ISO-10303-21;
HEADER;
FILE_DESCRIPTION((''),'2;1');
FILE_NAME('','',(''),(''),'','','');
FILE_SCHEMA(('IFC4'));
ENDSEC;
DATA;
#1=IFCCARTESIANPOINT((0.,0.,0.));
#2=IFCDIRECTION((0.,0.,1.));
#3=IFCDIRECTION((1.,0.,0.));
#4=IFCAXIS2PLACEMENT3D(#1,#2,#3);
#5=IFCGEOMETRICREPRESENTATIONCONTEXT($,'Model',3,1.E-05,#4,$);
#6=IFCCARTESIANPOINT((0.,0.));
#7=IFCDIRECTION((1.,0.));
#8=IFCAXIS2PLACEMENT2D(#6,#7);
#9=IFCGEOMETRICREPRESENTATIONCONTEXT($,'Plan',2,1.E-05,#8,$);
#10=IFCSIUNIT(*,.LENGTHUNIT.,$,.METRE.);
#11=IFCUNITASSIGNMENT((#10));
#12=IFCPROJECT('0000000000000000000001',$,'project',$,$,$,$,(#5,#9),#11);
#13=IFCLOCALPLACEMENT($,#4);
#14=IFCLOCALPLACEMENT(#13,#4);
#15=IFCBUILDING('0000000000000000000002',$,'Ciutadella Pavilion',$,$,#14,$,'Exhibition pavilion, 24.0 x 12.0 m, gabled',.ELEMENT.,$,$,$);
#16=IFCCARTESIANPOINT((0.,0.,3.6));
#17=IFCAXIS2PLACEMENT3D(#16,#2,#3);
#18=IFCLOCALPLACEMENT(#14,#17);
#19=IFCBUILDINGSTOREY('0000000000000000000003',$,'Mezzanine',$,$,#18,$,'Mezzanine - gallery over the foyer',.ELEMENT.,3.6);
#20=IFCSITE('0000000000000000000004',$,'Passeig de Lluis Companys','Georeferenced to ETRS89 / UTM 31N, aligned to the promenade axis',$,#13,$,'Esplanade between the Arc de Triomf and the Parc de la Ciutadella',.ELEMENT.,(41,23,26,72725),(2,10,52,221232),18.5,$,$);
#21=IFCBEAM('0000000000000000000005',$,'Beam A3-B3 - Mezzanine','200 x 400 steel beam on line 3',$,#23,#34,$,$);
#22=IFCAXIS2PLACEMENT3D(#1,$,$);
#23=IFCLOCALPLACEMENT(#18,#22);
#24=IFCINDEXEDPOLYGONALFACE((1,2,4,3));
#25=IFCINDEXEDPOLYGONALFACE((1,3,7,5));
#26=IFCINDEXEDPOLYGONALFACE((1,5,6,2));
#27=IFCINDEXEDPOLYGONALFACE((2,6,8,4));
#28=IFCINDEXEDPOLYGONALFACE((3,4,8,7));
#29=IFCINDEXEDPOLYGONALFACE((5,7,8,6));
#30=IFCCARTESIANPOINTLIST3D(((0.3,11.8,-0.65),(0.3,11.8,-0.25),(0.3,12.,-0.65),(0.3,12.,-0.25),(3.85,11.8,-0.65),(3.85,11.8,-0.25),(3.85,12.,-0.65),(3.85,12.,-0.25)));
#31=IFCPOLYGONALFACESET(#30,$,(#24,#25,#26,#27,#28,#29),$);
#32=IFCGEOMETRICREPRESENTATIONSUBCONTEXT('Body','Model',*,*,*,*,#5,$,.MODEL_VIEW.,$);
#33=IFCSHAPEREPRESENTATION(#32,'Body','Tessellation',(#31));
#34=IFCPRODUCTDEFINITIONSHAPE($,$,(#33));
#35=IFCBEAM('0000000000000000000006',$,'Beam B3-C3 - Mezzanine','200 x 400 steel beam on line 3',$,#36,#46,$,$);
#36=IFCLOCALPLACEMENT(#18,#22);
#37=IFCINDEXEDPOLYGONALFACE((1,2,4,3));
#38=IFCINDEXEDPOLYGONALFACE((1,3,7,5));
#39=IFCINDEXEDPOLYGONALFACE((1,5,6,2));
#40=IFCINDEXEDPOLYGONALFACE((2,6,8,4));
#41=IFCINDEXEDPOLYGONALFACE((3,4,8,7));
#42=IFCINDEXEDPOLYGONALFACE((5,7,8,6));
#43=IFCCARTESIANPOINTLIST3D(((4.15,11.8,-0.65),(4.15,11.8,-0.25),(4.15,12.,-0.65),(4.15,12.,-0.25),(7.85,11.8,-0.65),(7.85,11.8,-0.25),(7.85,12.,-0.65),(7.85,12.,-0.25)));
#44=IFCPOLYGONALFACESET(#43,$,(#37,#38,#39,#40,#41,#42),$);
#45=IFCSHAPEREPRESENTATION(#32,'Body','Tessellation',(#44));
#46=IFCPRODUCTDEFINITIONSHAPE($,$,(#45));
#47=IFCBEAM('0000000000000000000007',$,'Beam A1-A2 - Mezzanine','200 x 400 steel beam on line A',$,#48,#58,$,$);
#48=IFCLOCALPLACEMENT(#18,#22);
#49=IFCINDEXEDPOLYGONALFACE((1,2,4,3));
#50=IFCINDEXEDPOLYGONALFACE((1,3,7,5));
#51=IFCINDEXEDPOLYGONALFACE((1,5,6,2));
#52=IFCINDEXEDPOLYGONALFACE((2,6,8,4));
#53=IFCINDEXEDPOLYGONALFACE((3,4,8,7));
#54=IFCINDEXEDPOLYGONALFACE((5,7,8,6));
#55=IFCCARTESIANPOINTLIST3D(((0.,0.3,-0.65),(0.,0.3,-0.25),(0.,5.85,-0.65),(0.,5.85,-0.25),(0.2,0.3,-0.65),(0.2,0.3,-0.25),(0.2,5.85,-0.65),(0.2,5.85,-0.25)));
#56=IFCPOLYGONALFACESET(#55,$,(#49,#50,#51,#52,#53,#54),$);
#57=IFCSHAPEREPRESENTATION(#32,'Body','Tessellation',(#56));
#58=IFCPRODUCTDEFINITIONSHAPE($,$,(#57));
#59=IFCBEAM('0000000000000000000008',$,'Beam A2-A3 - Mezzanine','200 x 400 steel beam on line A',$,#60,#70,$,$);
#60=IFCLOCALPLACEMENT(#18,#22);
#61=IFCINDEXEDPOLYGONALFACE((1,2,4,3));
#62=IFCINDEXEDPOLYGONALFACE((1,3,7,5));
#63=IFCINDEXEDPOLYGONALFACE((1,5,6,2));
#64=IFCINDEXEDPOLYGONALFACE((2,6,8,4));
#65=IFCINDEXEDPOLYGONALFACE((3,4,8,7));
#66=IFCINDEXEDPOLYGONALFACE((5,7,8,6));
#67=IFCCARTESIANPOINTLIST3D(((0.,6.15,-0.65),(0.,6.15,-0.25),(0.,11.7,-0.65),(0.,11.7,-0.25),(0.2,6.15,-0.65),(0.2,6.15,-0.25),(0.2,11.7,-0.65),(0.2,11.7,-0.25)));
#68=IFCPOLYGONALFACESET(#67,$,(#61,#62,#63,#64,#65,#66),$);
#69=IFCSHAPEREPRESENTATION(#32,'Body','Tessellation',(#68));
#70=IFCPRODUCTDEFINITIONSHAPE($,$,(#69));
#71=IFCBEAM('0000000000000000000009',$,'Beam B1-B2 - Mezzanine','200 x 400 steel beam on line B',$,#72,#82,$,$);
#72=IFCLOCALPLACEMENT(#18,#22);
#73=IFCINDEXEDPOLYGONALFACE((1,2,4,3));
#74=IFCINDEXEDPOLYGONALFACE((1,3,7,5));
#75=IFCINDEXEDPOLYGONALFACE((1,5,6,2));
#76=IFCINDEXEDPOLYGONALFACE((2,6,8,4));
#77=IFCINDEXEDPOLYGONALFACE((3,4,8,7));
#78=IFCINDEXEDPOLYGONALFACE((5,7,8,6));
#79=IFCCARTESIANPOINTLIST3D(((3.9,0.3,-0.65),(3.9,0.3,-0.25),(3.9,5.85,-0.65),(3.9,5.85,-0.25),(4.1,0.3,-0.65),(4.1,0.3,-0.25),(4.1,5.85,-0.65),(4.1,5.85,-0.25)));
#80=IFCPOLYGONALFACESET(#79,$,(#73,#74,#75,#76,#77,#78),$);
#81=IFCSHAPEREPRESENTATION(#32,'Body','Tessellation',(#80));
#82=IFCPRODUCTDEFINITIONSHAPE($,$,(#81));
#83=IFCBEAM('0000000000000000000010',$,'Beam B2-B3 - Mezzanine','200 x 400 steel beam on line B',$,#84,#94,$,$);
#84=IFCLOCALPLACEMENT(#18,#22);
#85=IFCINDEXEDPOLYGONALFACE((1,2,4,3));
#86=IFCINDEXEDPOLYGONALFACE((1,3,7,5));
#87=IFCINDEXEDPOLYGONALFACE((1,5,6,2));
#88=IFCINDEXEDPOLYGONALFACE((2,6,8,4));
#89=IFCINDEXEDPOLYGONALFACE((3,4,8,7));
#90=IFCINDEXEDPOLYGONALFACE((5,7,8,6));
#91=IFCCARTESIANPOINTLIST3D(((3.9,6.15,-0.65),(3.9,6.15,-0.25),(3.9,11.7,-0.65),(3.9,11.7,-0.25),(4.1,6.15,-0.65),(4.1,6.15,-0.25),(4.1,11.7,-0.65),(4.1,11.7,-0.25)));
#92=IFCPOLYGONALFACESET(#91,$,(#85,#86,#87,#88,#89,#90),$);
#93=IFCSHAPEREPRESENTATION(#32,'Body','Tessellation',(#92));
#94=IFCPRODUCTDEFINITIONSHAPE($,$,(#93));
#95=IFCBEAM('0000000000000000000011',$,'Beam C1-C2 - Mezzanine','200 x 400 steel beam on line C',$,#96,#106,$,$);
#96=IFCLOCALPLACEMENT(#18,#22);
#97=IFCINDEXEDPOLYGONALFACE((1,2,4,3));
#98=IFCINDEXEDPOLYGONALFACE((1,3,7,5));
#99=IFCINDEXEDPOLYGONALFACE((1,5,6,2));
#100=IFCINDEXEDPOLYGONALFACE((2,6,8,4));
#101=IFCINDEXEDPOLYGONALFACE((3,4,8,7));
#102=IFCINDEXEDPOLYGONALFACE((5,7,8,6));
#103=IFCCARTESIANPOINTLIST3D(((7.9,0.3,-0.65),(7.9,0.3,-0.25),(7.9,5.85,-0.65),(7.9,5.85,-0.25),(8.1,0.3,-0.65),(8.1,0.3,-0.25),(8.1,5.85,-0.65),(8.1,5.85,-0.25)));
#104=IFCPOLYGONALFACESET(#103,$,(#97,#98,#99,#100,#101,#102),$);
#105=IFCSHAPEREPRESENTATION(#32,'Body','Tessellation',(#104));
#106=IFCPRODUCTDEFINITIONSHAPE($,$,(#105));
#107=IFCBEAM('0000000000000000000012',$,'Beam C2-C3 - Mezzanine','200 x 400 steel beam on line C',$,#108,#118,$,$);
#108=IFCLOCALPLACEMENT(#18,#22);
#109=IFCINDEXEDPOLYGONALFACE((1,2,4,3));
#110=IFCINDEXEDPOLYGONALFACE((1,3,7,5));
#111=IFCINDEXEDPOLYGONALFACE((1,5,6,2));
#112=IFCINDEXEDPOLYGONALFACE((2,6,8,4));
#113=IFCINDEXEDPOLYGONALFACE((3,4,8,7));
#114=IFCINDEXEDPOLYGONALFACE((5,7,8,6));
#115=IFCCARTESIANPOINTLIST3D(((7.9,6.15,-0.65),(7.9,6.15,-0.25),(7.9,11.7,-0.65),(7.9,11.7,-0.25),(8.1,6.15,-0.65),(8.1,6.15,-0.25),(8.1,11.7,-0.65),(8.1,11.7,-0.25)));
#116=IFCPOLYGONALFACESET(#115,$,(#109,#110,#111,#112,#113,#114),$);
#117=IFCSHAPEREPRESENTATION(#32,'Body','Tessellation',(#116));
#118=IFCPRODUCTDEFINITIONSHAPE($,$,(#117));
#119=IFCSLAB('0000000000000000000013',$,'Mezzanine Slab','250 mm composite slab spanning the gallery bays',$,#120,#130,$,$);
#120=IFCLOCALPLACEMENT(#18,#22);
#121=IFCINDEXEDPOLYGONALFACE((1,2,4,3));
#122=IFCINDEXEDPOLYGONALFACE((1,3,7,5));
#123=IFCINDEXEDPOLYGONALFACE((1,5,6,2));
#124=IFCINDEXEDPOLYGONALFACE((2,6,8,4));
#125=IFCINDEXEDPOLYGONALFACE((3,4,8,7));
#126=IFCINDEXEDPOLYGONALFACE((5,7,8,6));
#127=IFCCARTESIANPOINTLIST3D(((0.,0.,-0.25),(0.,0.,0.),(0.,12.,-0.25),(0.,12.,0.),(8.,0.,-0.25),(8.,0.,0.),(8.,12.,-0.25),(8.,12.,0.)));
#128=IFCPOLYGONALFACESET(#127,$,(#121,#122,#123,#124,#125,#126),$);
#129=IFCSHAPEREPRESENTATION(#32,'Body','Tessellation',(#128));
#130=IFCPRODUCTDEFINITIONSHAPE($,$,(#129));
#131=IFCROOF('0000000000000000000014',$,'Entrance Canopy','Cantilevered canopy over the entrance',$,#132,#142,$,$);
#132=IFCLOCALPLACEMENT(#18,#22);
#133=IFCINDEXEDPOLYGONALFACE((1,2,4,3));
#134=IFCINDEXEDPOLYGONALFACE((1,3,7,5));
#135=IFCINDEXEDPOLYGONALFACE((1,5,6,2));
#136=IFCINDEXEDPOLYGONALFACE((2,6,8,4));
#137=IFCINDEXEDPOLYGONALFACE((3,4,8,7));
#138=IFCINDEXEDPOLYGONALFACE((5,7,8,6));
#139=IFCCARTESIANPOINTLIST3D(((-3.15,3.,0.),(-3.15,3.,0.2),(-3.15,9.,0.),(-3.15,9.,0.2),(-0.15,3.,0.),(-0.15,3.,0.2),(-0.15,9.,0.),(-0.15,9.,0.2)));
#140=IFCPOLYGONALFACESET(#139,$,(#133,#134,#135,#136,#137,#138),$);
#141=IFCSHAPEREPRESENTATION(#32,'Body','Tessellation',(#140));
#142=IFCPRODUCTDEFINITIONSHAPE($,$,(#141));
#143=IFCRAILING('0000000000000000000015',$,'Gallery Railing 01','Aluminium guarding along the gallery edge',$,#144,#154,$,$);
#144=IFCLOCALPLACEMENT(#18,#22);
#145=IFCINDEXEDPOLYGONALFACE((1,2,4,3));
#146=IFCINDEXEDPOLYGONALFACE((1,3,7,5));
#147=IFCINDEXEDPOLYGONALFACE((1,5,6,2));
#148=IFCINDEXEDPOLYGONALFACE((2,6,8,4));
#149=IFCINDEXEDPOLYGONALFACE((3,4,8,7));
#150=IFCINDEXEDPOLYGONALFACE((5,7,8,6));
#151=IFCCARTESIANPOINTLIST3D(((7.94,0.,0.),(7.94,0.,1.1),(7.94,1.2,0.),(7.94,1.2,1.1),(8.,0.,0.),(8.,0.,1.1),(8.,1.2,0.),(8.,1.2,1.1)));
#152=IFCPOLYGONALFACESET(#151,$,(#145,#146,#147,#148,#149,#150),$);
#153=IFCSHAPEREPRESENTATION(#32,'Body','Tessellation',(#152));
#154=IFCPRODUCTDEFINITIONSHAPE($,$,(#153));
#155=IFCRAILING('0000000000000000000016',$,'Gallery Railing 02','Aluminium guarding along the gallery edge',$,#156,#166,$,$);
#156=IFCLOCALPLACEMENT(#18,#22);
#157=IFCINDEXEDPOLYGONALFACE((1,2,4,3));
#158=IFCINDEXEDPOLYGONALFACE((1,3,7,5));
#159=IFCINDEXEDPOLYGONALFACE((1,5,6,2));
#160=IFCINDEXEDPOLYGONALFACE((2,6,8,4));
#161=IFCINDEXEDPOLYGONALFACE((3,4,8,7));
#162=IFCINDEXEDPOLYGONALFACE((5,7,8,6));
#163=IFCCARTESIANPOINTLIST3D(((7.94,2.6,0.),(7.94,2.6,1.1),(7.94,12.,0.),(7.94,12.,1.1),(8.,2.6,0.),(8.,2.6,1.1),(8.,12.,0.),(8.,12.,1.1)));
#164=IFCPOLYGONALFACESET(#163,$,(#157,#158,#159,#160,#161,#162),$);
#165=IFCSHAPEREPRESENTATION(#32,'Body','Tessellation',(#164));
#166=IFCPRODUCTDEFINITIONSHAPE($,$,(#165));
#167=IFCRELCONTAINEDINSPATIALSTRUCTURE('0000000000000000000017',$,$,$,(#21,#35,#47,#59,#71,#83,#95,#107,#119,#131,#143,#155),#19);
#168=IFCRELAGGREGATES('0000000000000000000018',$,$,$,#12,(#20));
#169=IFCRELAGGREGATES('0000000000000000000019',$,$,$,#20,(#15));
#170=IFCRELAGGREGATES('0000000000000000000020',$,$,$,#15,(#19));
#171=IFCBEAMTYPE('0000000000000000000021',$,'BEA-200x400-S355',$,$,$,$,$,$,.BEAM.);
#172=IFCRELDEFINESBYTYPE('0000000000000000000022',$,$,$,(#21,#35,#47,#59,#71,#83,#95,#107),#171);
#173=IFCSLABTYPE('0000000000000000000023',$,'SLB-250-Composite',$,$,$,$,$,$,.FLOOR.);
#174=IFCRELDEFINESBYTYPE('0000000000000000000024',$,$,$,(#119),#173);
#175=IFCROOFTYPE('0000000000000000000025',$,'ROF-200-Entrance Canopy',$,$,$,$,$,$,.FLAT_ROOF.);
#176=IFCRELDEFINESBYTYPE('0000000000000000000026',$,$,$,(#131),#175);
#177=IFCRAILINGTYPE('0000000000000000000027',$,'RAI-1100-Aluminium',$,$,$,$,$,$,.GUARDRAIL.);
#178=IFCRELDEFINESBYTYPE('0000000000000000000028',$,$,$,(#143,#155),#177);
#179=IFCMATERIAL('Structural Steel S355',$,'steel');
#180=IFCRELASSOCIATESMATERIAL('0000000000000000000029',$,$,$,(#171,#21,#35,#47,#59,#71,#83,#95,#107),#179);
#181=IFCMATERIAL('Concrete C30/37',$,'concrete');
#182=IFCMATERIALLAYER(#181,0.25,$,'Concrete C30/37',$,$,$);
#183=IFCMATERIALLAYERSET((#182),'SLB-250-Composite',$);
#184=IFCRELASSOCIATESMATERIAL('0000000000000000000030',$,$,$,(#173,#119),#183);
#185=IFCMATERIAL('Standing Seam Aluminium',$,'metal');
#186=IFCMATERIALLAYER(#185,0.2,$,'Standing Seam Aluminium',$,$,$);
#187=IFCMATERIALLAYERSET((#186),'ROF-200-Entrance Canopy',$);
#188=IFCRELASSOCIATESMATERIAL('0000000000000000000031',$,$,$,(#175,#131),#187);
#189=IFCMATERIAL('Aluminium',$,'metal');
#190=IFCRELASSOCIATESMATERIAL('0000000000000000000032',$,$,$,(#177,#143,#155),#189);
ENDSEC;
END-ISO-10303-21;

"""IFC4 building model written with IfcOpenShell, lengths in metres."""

from ifc_helpers import new_model, si_unit, frame, origin_with_axes, origin_2d_with_axis, place, context, subcontext, project, spatial, line, indexed_curve, rectangle, outline, extrude, material, layer, layer_set, layer_usage, material_profile, profile_set, profile_usage, type_object, element, save


model = new_model("IFC4")

# Units and contexts
model_context = context("Model", 3, precision=1e-05, world=origin_with_axes())
plan_context = context("Plan", 2, precision=1e-05, world=origin_2d_with_axis())
body_context = subcontext(model_context, "Body", "Model", "MODEL_VIEW")
ifc_project = project(units=[si_unit("LENGTHUNIT", "METRE")], contexts=[model_context, plan_context])

# Site, building, storey
site_placement = place(None, origin_with_axes())
site = spatial("IfcSite", under=ifc_project, at=site_placement, Name="Passeig de Lluis Companys", Description="Georeferenced to ETRS89 / UTM 31N, aligned to the promenade axis", LongName="Esplanade between the Arc de Triomf and the Parc de la Ciutadella", CompositionType="ELEMENT", RefLatitude=(41, 23, 26, 72725), RefLongitude=(2, 10, 52, 221232), RefElevation=18.5)
building_placement = place(site_placement, origin_with_axes())
building = spatial("IfcBuilding", under=site, at=building_placement, Name="Ciutadella Pavilion", LongName="Exhibition pavilion, 24.0 x 12.0 m, gabled", CompositionType="ELEMENT")
storey_placement = place(building_placement, frame((0.0, 0.0, 3.6), z_axis=(0.0, 0.0, 1.0), x_axis=(1.0, 0.0, 0.0)))
storey = spatial("IfcBuildingStorey", under=building, at=storey_placement, Name="Mezzanine", LongName="Mezzanine - gallery over the foyer", CompositionType="ELEMENT", Elevation=3.6)

# Shared definitions
ifc_material_1 = material(Name="Structural Steel S355", Category="steel")

# Beams
ifc_material_profile_1 = material_profile(ifc_material_1, rectangle(XDim=0.2, YDim=0.4))
ifc_profile_set_1 = profile_set([ifc_material_profile_1], Name="BEA-200x400-S355")
beam_type = type_object("IfcBeamType", Name="BEA-200x400-S355", PredefinedType="BEAM", material=ifc_profile_set_1)
ifc_profile_usage_1 = profile_usage(ifc_profile_set_1)
beam_1_placement = place(storey_placement, frame((0.3, 11.8, -0.65), z_axis=(1.0, 0.0, 0.0), x_axis=(0.0, 1.0, 0.0)))
element("IfcBeam", 1, at=beam_1_placement, inside=storey, type_object=beam_type, material=ifc_profile_usage_1, Name="Beam A3-B3 - Mezzanine", Description="200 x 400 steel beam on line 3", context=body_context, shape_type="SweptSolid", body=[
    extrude(outline(indexed_curve([(0.0, 0.0), (0.2, 0.0), (0.2, 0.4), (0.0, 0.4)], segments=[line(1, 2, 3, 4, 1)])), origin_with_axes(), (0.0, 0.0, 1.0), 3.55),
])
ifc_profile_usage_2 = profile_usage(ifc_profile_set_1)
beam_2_placement = place(storey_placement, frame((4.15, 11.8, -0.65), z_axis=(1.0, 0.0, 0.0), x_axis=(0.0, 1.0, 0.0)))
element("IfcBeam", 2, at=beam_2_placement, inside=storey, type_object=beam_type, material=ifc_profile_usage_2, Name="Beam B3-C3 - Mezzanine", Description="200 x 400 steel beam on line 3", context=body_context, shape_type="SweptSolid", body=[
    extrude(outline(indexed_curve([(0.0, 0.0), (0.2, 0.0), (0.2, 0.4), (0.0, 0.4)], segments=[line(1, 2, 3, 4, 1)])), origin_with_axes(), (0.0, 0.0, 1.0), 3.7),
])
ifc_profile_usage_3 = profile_usage(ifc_profile_set_1)
beam_3_placement = place(storey_placement, frame((0.0, 0.3, -0.65), z_axis=(0.0, 1.0, 0.0), x_axis=(0.0, 0.0, 1.0)))
element("IfcBeam", 3, at=beam_3_placement, inside=storey, type_object=beam_type, material=ifc_profile_usage_3, Name="Beam A1-A2 - Mezzanine", Description="200 x 400 steel beam on line A", context=body_context, shape_type="SweptSolid", body=[
    extrude(outline(indexed_curve([(0.0, 0.0), (0.4, 0.0), (0.4, 0.2), (0.0, 0.2)], segments=[line(1, 2, 3, 4, 1)])), origin_with_axes(), (0.0, 0.0, 1.0), 5.55),
])
ifc_profile_usage_4 = profile_usage(ifc_profile_set_1)
beam_4_placement = place(storey_placement, frame((0.0, 6.15, -0.65), z_axis=(0.0, 1.0, 0.0), x_axis=(0.0, 0.0, 1.0)))
element("IfcBeam", 4, at=beam_4_placement, inside=storey, type_object=beam_type, material=ifc_profile_usage_4, Name="Beam A2-A3 - Mezzanine", Description="200 x 400 steel beam on line A", context=body_context, shape_type="SweptSolid", body=[
    extrude(outline(indexed_curve([(0.0, 0.0), (0.4, 0.0), (0.4, 0.2), (0.0, 0.2)], segments=[line(1, 2, 3, 4, 1)])), origin_with_axes(), (0.0, 0.0, 1.0), 5.55),
])
ifc_profile_usage_5 = profile_usage(ifc_profile_set_1)
beam_5_placement = place(storey_placement, frame((3.9, 0.3, -0.65), z_axis=(0.0, 1.0, 0.0), x_axis=(0.0, 0.0, 1.0)))
element("IfcBeam", 5, at=beam_5_placement, inside=storey, type_object=beam_type, material=ifc_profile_usage_5, Name="Beam B1-B2 - Mezzanine", Description="200 x 400 steel beam on line B", context=body_context, shape_type="SweptSolid", body=[
    extrude(outline(indexed_curve([(0.0, 0.0), (0.4, 0.0), (0.4, 0.2), (0.0, 0.2)], segments=[line(1, 2, 3, 4, 1)])), origin_with_axes(), (0.0, 0.0, 1.0), 5.55),
])
ifc_profile_usage_6 = profile_usage(ifc_profile_set_1)
beam_6_placement = place(storey_placement, frame((3.9, 6.15, -0.65), z_axis=(0.0, 1.0, 0.0), x_axis=(0.0, 0.0, 1.0)))
element("IfcBeam", 6, at=beam_6_placement, inside=storey, type_object=beam_type, material=ifc_profile_usage_6, Name="Beam B2-B3 - Mezzanine", Description="200 x 400 steel beam on line B", context=body_context, shape_type="SweptSolid", body=[
    extrude(outline(indexed_curve([(0.0, 0.0), (0.4, 0.0), (0.4, 0.2), (0.0, 0.2)], segments=[line(1, 2, 3, 4, 1)])), origin_with_axes(), (0.0, 0.0, 1.0), 5.55),
])
ifc_profile_usage_7 = profile_usage(ifc_profile_set_1)
beam_7_placement = place(storey_placement, frame((7.9, 0.3, -0.65), z_axis=(0.0, 1.0, 0.0), x_axis=(0.0, 0.0, 1.0)))
element("IfcBeam", 7, at=beam_7_placement, inside=storey, type_object=beam_type, material=ifc_profile_usage_7, Name="Beam C1-C2 - Mezzanine", Description="200 x 400 steel beam on line C", context=body_context, shape_type="SweptSolid", body=[
    extrude(outline(indexed_curve([(0.0, 0.0), (0.4, 0.0), (0.4, 0.2), (0.0, 0.2)], segments=[line(1, 2, 3, 4, 1)])), origin_with_axes(), (0.0, 0.0, 1.0), 5.55),
])
ifc_profile_usage_8 = profile_usage(ifc_profile_set_1)
beam_8_placement = place(storey_placement, frame((7.9, 6.15, -0.65), z_axis=(0.0, 1.0, 0.0), x_axis=(0.0, 0.0, 1.0)))
element("IfcBeam", 8, at=beam_8_placement, inside=storey, type_object=beam_type, material=ifc_profile_usage_8, Name="Beam C2-C3 - Mezzanine", Description="200 x 400 steel beam on line C", context=body_context, shape_type="SweptSolid", body=[
    extrude(outline(indexed_curve([(0.0, 0.0), (0.4, 0.0), (0.4, 0.2), (0.0, 0.2)], segments=[line(1, 2, 3, 4, 1)])), origin_with_axes(), (0.0, 0.0, 1.0), 5.55),
])

# Slab
ifc_material_2 = material(Name="Concrete C30/37", Category="concrete")
ifc_layer_1 = layer(ifc_material_2, 0.25, Name="Concrete C30/37")
ifc_layer_set_1 = layer_set([ifc_layer_1], Name="SLB-250-Composite")
ifc_layer_usage_1 = layer_usage(ifc_layer_set_1, "AXIS3", "POSITIVE", 0.0)
slab_type = type_object("IfcSlabType", Name="SLB-250-Composite", PredefinedType="FLOOR", material=ifc_layer_set_1)
slab_placement = place(storey_placement, frame((0.0, 0.0, -0.25), z_axis=(0.0, 0.0, 1.0), x_axis=(1.0, 0.0, 0.0)))
element("IfcSlab", 9, at=slab_placement, inside=storey, type_object=slab_type, material=ifc_layer_usage_1, Name="Mezzanine Slab", Description="250 mm composite slab spanning the gallery bays", context=body_context, shape_type="SweptSolid", body=[
    extrude(outline(indexed_curve([(0.0, 0.0), (8.0, 0.0), (8.0, 12.0), (0.0, 12.0)], segments=[line(1, 2, 3, 4, 1)])), origin_with_axes(), (0.0, 0.0, 1.0), 0.25),
])

# Roof
ifc_material_3 = material(Name="Standing Seam Aluminium", Category="metal")
ifc_layer_2 = layer(ifc_material_3, 0.2, Name="Standing Seam Aluminium")
ifc_layer_set_2 = layer_set([ifc_layer_2], Name="ROF-200-Entrance Canopy")
ifc_layer_usage_2 = layer_usage(ifc_layer_set_2, "AXIS3", "POSITIVE", 0.0)
roof_type = type_object("IfcRoofType", Name="ROF-200-Entrance Canopy", PredefinedType="FLAT_ROOF", material=ifc_layer_set_2)
roof_placement = place(storey_placement, frame((-3.15, 3.0, 0.0), z_axis=(0.0, 0.0, 1.0), x_axis=(1.0, 0.0, 0.0)))
element("IfcRoof", 10, at=roof_placement, inside=storey, type_object=roof_type, material=ifc_layer_usage_2, Name="Entrance Canopy", Description="Cantilevered canopy over the entrance", context=body_context, shape_type="SweptSolid", body=[
    extrude(outline(indexed_curve([(0.0, 0.0), (3.0, 0.0), (3.0, 6.0), (0.0, 6.0)], segments=[line(1, 2, 3, 4, 1)])), origin_with_axes(), (0.0, 0.0, 1.0), 0.2),
])

# Railings
ifc_material_4 = material(Name="Aluminium", Category="metal")
railing_type = type_object("IfcRailingType", Name="RAI-1100-Aluminium", PredefinedType="GUARDRAIL", material=ifc_material_4)
railing_1_placement = place(storey_placement, frame((7.94, 0.0, 0.0), z_axis=(0.0, 0.0, 1.0), x_axis=(1.0, 0.0, 0.0)))
element("IfcRailing", 11, at=railing_1_placement, inside=storey, type_object=railing_type, material=ifc_material_4, Name="Gallery Railing 01", Description="Aluminium guarding along the gallery edge", context=body_context, shape_type="SweptSolid", body=[
    extrude(outline(indexed_curve([(0.0, 0.0), (0.06, 0.0), (0.06, 1.2), (0.0, 1.2)], segments=[line(1, 2, 3, 4, 1)])), origin_with_axes(), (0.0, 0.0, 1.0), 1.1),
])
railing_2_placement = place(storey_placement, frame((7.94, 2.6, 0.0), z_axis=(0.0, 0.0, 1.0), x_axis=(1.0, 0.0, 0.0)))
element("IfcRailing", 12, at=railing_2_placement, inside=storey, type_object=railing_type, material=ifc_material_4, Name="Gallery Railing 02", Description="Aluminium guarding along the gallery edge", context=body_context, shape_type="SweptSolid", body=[
    extrude(outline(indexed_curve([(0.0, 0.0), (0.06, 0.0), (0.06, 9.4), (0.0, 9.4)], segments=[line(1, 2, 3, 4, 1)])), origin_with_axes(), (0.0, 0.0, 1.0), 1.1),
])

save(model, "model.ifc")
